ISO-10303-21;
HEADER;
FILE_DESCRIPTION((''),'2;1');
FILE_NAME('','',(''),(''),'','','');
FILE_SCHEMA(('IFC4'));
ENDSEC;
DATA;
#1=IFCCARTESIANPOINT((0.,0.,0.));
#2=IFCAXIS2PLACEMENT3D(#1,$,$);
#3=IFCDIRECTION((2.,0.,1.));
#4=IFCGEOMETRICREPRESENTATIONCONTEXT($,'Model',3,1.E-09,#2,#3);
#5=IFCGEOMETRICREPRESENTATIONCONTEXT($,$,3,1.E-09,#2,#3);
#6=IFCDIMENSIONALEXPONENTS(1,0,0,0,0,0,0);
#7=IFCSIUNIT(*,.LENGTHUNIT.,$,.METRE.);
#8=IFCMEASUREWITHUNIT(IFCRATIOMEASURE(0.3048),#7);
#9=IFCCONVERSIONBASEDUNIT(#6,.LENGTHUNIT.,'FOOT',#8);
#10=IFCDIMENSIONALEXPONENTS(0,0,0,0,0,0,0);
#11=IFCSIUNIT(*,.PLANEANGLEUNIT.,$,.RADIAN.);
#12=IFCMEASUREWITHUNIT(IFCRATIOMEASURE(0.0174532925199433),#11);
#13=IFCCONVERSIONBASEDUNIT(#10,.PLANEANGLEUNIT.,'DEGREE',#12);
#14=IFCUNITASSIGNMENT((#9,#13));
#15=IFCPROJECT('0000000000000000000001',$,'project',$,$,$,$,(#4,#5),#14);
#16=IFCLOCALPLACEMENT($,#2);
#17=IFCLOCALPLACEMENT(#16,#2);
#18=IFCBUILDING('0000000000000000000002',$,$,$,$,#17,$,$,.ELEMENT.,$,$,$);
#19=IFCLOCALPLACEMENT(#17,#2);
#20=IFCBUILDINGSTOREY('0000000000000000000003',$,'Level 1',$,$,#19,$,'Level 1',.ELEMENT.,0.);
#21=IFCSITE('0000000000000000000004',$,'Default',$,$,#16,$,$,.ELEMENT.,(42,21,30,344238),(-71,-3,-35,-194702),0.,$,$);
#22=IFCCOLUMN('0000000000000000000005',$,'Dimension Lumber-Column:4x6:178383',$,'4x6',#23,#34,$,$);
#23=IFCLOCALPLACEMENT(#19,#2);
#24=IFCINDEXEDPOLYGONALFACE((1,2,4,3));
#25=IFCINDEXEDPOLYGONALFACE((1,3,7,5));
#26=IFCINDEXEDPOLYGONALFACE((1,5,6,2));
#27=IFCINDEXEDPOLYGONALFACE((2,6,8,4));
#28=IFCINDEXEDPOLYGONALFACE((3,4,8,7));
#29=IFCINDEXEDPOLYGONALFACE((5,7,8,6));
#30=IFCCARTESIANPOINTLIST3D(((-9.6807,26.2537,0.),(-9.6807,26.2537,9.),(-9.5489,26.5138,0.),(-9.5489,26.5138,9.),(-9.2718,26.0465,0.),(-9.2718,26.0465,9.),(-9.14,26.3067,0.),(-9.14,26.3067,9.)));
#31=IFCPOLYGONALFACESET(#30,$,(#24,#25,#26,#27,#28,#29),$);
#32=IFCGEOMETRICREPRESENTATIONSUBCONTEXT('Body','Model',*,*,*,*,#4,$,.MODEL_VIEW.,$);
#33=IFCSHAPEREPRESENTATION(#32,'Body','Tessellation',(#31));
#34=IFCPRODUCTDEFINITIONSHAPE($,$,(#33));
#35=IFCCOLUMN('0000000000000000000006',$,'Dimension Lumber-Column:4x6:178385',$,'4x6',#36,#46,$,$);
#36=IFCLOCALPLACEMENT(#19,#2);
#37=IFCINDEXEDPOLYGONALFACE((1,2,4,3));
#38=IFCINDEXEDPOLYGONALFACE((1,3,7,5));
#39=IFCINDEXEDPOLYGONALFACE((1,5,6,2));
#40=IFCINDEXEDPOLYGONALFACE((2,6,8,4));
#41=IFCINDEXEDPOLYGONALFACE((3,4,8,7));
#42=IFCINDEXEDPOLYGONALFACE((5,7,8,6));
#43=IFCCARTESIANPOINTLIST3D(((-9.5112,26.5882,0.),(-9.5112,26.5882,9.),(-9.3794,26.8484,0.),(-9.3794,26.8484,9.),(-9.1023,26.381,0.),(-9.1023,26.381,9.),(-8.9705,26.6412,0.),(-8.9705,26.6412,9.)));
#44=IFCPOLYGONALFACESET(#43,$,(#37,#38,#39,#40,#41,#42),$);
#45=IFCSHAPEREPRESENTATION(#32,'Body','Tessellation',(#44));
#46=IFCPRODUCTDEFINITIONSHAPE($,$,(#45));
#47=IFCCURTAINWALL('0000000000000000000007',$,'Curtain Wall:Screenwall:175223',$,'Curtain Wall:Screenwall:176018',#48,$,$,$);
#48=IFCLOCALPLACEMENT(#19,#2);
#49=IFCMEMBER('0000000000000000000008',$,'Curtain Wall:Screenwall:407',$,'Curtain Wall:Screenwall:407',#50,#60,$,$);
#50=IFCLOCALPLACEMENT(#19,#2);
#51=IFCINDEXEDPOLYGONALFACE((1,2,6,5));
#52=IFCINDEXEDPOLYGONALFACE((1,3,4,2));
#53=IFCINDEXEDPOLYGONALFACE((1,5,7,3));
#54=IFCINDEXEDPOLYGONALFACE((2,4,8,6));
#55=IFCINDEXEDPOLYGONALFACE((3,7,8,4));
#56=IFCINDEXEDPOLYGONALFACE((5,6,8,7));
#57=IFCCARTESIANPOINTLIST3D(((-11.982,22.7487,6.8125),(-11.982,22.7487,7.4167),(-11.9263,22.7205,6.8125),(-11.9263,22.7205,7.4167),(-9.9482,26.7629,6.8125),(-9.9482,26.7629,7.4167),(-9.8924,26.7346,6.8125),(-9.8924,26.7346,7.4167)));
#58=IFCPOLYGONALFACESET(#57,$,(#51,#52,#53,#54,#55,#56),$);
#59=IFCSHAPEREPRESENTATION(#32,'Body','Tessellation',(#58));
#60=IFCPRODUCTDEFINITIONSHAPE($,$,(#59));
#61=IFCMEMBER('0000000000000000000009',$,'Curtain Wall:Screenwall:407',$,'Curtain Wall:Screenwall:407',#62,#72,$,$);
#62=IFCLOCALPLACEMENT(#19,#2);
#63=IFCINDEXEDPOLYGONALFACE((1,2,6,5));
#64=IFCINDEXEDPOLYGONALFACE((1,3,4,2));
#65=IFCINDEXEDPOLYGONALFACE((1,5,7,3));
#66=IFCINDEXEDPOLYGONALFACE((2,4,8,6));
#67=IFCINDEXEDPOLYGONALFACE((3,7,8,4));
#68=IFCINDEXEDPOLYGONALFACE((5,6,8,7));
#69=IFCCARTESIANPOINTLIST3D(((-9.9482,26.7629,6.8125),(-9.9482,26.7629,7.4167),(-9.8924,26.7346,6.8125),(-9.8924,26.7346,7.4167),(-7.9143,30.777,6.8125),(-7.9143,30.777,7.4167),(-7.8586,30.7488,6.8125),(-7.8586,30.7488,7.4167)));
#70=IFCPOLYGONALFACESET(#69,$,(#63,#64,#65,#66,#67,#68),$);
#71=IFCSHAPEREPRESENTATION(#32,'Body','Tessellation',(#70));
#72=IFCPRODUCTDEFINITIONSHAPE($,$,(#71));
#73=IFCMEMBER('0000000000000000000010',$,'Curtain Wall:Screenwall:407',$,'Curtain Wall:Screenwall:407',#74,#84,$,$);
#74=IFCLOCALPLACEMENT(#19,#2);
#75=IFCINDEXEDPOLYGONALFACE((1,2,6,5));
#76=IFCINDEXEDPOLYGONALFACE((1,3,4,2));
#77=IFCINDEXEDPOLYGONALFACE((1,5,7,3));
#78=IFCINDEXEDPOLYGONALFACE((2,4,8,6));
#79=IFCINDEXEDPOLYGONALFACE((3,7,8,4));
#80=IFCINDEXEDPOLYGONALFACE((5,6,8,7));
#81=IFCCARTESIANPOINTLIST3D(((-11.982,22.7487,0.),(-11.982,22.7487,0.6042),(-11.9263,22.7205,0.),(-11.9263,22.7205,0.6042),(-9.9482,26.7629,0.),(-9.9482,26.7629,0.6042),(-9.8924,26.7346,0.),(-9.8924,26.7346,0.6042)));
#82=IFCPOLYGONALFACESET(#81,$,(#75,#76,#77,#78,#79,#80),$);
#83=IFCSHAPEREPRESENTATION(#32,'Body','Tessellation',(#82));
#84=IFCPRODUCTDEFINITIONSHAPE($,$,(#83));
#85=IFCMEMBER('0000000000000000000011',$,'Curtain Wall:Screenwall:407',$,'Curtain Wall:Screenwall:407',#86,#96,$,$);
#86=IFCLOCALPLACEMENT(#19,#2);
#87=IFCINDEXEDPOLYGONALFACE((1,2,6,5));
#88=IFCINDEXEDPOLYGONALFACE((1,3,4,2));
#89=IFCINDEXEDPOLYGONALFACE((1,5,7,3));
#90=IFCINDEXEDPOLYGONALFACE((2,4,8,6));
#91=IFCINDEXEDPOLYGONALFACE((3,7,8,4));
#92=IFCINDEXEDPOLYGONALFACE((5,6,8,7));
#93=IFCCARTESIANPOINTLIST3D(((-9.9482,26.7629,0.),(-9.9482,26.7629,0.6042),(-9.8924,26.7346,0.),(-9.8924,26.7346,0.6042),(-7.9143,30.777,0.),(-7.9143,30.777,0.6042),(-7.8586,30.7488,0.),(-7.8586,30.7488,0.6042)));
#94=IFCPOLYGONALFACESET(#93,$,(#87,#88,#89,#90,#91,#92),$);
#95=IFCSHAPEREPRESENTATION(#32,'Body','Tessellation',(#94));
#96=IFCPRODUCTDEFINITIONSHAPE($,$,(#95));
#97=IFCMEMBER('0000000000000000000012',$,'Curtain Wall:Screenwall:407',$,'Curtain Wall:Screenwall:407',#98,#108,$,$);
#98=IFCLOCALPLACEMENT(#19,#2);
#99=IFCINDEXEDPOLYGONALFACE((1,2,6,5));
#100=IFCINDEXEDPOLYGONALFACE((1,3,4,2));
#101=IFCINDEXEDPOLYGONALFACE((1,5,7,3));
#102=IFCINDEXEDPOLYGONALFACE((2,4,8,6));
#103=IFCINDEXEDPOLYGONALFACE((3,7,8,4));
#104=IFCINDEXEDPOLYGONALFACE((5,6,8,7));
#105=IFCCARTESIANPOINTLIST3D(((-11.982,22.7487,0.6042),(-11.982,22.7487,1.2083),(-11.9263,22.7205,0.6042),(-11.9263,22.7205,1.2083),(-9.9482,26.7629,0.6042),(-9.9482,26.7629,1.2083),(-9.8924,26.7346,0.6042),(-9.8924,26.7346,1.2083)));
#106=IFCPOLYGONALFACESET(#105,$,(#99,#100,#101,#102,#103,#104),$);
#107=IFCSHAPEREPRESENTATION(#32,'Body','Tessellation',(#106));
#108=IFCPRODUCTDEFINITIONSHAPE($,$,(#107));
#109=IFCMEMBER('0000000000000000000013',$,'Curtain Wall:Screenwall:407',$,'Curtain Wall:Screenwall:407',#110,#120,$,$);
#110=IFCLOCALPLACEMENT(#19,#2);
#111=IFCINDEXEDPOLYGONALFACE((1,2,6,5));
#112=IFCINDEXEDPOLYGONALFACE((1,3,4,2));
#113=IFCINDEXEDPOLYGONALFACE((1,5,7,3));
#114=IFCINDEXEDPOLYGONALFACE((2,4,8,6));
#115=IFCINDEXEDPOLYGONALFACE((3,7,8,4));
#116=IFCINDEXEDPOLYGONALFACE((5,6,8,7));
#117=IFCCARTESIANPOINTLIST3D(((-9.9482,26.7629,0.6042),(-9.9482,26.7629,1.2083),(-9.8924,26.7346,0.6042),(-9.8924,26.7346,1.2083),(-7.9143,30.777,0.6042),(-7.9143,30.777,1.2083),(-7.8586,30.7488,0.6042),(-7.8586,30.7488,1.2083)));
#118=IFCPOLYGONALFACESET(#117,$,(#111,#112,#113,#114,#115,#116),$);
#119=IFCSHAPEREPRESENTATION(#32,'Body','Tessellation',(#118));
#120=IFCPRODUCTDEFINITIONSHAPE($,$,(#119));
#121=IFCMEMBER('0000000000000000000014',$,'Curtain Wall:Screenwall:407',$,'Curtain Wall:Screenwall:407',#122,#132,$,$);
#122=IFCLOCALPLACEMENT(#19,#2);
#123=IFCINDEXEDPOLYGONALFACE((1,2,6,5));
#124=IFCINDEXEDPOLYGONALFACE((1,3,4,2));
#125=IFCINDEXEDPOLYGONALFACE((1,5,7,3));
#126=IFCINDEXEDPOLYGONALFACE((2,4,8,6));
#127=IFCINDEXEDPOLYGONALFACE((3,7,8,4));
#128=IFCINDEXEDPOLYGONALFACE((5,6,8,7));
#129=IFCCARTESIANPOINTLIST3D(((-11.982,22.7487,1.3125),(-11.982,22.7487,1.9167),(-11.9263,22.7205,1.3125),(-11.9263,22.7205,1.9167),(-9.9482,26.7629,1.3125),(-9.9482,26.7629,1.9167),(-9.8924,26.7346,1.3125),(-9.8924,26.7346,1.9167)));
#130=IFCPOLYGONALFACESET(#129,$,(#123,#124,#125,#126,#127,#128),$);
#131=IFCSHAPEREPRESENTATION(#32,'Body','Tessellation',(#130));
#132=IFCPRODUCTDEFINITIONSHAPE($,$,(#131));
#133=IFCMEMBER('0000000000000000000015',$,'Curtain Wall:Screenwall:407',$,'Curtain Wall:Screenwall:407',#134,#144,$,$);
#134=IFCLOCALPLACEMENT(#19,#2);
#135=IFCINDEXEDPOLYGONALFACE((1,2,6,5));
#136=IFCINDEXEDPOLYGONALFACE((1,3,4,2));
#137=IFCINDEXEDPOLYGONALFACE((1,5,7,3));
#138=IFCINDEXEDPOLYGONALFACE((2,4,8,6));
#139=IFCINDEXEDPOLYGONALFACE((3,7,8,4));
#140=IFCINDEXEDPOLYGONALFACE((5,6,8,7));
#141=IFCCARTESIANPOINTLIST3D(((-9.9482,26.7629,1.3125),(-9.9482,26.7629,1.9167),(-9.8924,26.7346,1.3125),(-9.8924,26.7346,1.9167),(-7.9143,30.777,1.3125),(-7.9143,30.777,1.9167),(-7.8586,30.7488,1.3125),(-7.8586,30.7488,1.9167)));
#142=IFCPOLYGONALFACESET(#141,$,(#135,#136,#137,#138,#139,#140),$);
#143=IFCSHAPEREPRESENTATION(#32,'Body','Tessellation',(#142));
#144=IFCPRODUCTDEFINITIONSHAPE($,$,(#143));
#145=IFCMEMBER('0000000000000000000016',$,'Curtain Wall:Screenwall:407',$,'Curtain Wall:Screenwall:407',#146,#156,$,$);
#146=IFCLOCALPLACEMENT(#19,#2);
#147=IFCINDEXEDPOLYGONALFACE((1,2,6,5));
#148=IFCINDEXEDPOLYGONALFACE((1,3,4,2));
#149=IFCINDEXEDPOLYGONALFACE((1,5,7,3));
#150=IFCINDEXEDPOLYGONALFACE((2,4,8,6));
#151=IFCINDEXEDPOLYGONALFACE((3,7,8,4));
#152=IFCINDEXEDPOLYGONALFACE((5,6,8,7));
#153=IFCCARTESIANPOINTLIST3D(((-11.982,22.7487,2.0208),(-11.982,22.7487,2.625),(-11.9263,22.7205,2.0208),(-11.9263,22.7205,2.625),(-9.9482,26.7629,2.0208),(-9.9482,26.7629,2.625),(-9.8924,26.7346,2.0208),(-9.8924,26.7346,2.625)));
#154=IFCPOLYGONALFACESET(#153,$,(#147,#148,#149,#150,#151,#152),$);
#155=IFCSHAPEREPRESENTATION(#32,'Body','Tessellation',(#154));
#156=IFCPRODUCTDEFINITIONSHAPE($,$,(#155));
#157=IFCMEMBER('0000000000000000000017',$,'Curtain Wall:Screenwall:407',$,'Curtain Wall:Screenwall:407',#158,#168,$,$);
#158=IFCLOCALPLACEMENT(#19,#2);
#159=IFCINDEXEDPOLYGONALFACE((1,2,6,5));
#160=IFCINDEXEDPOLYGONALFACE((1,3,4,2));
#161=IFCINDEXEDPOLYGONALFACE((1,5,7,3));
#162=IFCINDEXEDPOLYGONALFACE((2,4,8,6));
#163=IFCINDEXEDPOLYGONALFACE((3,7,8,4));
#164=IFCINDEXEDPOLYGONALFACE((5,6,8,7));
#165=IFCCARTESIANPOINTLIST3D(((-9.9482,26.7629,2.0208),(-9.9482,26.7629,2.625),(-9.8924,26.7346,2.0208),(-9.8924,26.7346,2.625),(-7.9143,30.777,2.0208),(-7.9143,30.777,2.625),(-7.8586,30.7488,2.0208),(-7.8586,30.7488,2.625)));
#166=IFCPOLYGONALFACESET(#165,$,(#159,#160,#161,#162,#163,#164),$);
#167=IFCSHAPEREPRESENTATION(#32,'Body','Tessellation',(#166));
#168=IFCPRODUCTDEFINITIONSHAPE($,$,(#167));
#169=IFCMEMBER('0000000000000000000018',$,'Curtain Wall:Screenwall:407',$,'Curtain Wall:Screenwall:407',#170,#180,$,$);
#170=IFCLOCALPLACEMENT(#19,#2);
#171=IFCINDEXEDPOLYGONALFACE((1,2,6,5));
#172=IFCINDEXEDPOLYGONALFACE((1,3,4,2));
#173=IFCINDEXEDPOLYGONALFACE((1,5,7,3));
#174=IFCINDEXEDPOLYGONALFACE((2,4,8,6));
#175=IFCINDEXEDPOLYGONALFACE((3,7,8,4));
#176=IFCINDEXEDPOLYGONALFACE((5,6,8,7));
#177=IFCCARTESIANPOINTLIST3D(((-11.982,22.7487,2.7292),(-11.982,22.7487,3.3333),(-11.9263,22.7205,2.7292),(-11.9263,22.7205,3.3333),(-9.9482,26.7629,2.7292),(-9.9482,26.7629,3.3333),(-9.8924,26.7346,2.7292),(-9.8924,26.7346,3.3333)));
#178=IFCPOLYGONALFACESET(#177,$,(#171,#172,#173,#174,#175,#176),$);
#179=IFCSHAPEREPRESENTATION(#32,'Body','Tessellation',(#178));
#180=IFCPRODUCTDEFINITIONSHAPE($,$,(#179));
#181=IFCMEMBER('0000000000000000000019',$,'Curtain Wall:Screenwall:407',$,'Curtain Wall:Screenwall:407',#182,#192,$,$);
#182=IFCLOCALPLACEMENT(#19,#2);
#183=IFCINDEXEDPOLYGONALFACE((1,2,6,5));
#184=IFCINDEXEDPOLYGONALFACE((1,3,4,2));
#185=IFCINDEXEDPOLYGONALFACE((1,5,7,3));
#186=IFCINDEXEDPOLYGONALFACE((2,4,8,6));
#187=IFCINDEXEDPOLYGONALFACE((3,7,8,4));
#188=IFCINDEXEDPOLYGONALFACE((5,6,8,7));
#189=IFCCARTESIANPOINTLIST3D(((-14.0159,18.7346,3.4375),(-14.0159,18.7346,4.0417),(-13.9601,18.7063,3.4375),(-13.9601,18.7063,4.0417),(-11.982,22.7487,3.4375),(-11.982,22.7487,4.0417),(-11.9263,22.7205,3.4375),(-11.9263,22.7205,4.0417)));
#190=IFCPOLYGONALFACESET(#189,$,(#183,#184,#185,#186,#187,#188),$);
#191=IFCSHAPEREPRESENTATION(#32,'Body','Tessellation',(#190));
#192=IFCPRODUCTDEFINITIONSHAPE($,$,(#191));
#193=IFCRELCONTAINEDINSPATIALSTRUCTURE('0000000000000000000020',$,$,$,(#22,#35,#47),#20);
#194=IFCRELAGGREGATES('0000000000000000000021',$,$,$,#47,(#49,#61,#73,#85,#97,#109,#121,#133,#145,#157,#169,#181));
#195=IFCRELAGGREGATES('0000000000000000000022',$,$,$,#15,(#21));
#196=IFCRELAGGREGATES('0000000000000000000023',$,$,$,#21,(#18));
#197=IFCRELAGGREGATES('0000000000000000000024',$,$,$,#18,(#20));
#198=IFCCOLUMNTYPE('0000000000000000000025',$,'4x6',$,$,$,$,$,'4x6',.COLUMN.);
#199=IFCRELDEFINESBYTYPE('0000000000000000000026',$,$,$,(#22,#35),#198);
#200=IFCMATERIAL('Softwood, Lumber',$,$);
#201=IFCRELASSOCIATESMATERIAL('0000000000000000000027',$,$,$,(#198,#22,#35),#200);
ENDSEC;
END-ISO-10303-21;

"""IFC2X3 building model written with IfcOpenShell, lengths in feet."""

from ifc_helpers import new_model, entity, si_unit, converted_unit, direction, frame, frame_2d, origin, origin_2d_with_axis, place, context, subcontext, project, spatial, rectangle, extrude, source, transform, mapped, material, type_object, type_shapes, element, aggregate, save


model = new_model("IFC2X3")

# Units and contexts
model_context = context("Model", 3, precision=1e-09, world=origin(), true_north=direction((2.0, 0.0, 1.0)))
context_of_model = context(None, 3, precision=1e-09, world=origin(), true_north=direction((2.0, 0.0, 1.0)))
body_context = subcontext(model_context, "Body", "Model", "MODEL_VIEW")
ifc_project = project(units=[converted_unit("LENGTHUNIT", "FOOT", entity("IfcRatioMeasure", 0.3048), si_unit("LENGTHUNIT", "METRE"), dimensions=[1, 0, 0, 0, 0, 0, 0]), converted_unit("PLANEANGLEUNIT", "DEGREE", entity("IfcRatioMeasure", 0.0174532925199433), si_unit("PLANEANGLEUNIT", "RADIAN"), dimensions=[0, 0, 0, 0, 0, 0, 0])], contexts=[model_context, context_of_model])

# Site, building, storey
site_placement = place(None, origin())
site = spatial("IfcSite", under=ifc_project, at=site_placement, Name="Default", CompositionType="ELEMENT", RefLatitude=(42, 21, 30, 344238), RefLongitude=(-71, -3, -35, -194702), RefElevation=0.0)
building_placement = place(site_placement, origin())
building = spatial("IfcBuilding", under=site, at=building_placement, CompositionType="ELEMENT")
storey_placement = place(building_placement, origin())
storey = spatial("IfcBuildingStorey", under=building, at=storey_placement, Name="Level 1", LongName="Level 1", CompositionType="ELEMENT", Elevation=0.0)

# Columns
ifc_material_1 = material(Name="Softwood, Lumber")
column_type = type_object("IfcColumnType", Name="4x6", ElementType="4x6", PredefinedType="COLUMN", material=ifc_material_1)
shared_shape_1 = source(origin(), body_context, "Body", "SweptSolid", [
    extrude(rectangle(XDim=0.2917, YDim=0.4583, at=origin_2d_with_axis()), frame((0.0, 0.0, 0.0), z_axis=(0.0, 0.0, 1.0), x_axis=(-1.0, 0.0, 0.0)), (0.0, 0.0, 1.0), 9.0),
])
type_shapes(column_type, [shared_shape_1])
for number, where, z_axis, x_axis, name in (
    (1, (-9.4103, 26.2802, 0.0), (0.0, 0.0, 1.0), (0.451968, 0.892034, 0.0), "Dimension Lumber-Column:4x6:178383"),
    (2, (-9.2409, 26.6147, 0.0), (0.0, 0.0, 1.0), (0.451968, 0.892034, 0.0), "Dimension Lumber-Column:4x6:178385"),
):
    element("IfcColumn", number, at=place(storey_placement, frame(where, z_axis=z_axis, x_axis=x_axis)), inside=storey, type_object=column_type, material=ifc_material_1, Name=name, ObjectType="4x6", context=body_context, shape_type="MappedRepresentation", body=[
        mapped(shared_shape_1, transform((0.0, 0.0, 0.0), scale=1.0)),
    ])

# Curtain wall, members
curtain_wall_placement = place(storey_placement, origin())
curtain_wall = element("IfcCurtainWall", 3, at=curtain_wall_placement, inside=storey, Name="Curtain Wall:Screenwall:175223", ObjectType="Curtain Wall:Screenwall:176018")
member_1_placement = place(curtain_wall_placement, frame((-11.982, 22.7205, 6.8125)))
member_1 = element("IfcMember", 4, at=member_1_placement, Name="Curtain Wall:Screenwall:407", ObjectType="Curtain Wall:Screenwall:407", context=body_context, shape_type="SweptSolid", body=[
    extrude(rectangle(XDim=4.5, YDim=0.0625, at=frame_2d((0.0, 0.0), x_axis=(1.0, 0.0))), frame((1.0448, 2.0212, 0.0), z_axis=(0.0, 0.0, 1.0), x_axis=(-0.451968, -0.892034, 0.0)), (0.0, 0.0, 1.0), 0.6042),
])
member_2_placement = place(curtain_wall_placement, frame((-9.9482, 26.7346, 6.8125)))
member_2 = element("IfcMember", 5, at=member_2_placement, Name="Curtain Wall:Screenwall:407", ObjectType="Curtain Wall:Screenwall:407", context=body_context, shape_type="SweptSolid", body=[
    extrude(rectangle(XDim=4.5, YDim=0.0625, at=frame_2d((0.0, 0.0), x_axis=(1.0, 0.0))), frame((1.0448, 2.0212, 0.0), z_axis=(0.0, 0.0, 1.0), x_axis=(-0.451968, -0.892034, 0.0)), (0.0, 0.0, 1.0), 0.6042),
])
member_3_placement = place(curtain_wall_placement, frame((-11.982, 22.7205, 0.0)))
member_3 = element("IfcMember", 6, at=member_3_placement, Name="Curtain Wall:Screenwall:407", ObjectType="Curtain Wall:Screenwall:407", context=body_context, shape_type="SweptSolid", body=[
    extrude(rectangle(XDim=4.5, YDim=0.0625, at=frame_2d((0.0, 0.0), x_axis=(1.0, 0.0))), frame((1.0448, 2.0212, 0.0), z_axis=(0.0, 0.0, 1.0), x_axis=(0.451968, 0.892034, 0.0)), (0.0, 0.0, 1.0), 0.6042),
])
member_4_placement = place(curtain_wall_placement, frame((-9.9482, 26.7346, 0.0)))
member_4 = element("IfcMember", 7, at=member_4_placement, Name="Curtain Wall:Screenwall:407", ObjectType="Curtain Wall:Screenwall:407", context=body_context, shape_type="SweptSolid", body=[
    extrude(rectangle(XDim=4.5, YDim=0.0625, at=frame_2d((0.0, 0.0), x_axis=(1.0, 0.0))), frame((1.0448, 2.0212, 0.0), z_axis=(0.0, 0.0, 1.0), x_axis=(0.451968, 0.892034, 0.0)), (0.0, 0.0, 1.0), 0.6042),
])
member_5_placement = place(curtain_wall_placement, frame((-11.982, 22.7205, 0.6042)))
member_5 = element("IfcMember", 8, at=member_5_placement, Name="Curtain Wall:Screenwall:407", ObjectType="Curtain Wall:Screenwall:407", context=body_context, shape_type="SweptSolid", body=[
    extrude(rectangle(XDim=4.5, YDim=0.0625, at=frame_2d((0.0, 0.0), x_axis=(1.0, 0.0))), frame((1.0448, 2.0212, 0.0), z_axis=(0.0, 0.0, 1.0), x_axis=(-0.451968, -0.892034, 0.0)), (0.0, 0.0, 1.0), 0.6042),
])
member_6_placement = place(curtain_wall_placement, frame((-9.9482, 26.7346, 0.6042)))
member_6 = element("IfcMember", 9, at=member_6_placement, Name="Curtain Wall:Screenwall:407", ObjectType="Curtain Wall:Screenwall:407", context=body_context, shape_type="SweptSolid", body=[
    extrude(rectangle(XDim=4.5, YDim=0.0625, at=origin_2d_with_axis()), frame((1.0448, 2.0212, 0.0), z_axis=(0.0, 0.0, 1.0), x_axis=(-0.451968, -0.892034, 0.0)), (0.0, 0.0, 1.0), 0.6042),
])
member_7_placement = place(curtain_wall_placement, frame((-11.982, 22.7205, 1.3125)))
member_7 = element("IfcMember", 10, at=member_7_placement, Name="Curtain Wall:Screenwall:407", ObjectType="Curtain Wall:Screenwall:407", context=body_context, shape_type="SweptSolid", body=[
    extrude(rectangle(XDim=4.5, YDim=0.0625, at=frame_2d((0.0, 0.0), x_axis=(1.0, 0.0))), frame((1.0448, 2.0212, 0.0), z_axis=(0.0, 0.0, 1.0), x_axis=(-0.451968, -0.892034, 0.0)), (0.0, 0.0, 1.0), 0.6042),
])
member_8_placement = place(curtain_wall_placement, frame((-9.9482, 26.7346, 1.3125)))
member_8 = element("IfcMember", 11, at=member_8_placement, Name="Curtain Wall:Screenwall:407", ObjectType="Curtain Wall:Screenwall:407", context=body_context, shape_type="SweptSolid", body=[
    extrude(rectangle(XDim=4.5, YDim=0.0625, at=origin_2d_with_axis()), frame((1.0448, 2.0212, 0.0), z_axis=(0.0, 0.0, 1.0), x_axis=(-0.451968, -0.892034, 0.0)), (0.0, 0.0, 1.0), 0.6042),
])
member_9_placement = place(curtain_wall_placement, frame((-11.982, 22.7205, 2.0208)))
member_9 = element("IfcMember", 12, at=member_9_placement, Name="Curtain Wall:Screenwall:407", ObjectType="Curtain Wall:Screenwall:407", context=body_context, shape_type="SweptSolid", body=[
    extrude(rectangle(XDim=4.5, YDim=0.0625, at=frame_2d((0.0, 0.0), x_axis=(1.0, 0.0))), frame((1.0448, 2.0212, 0.0), z_axis=(0.0, 0.0, 1.0), x_axis=(-0.451968, -0.892034, 0.0)), (0.0, 0.0, 1.0), 0.6042),
])
member_10_placement = place(curtain_wall_placement, frame((-9.9482, 26.7346, 2.0208)))
member_10 = element("IfcMember", 13, at=member_10_placement, Name="Curtain Wall:Screenwall:407", ObjectType="Curtain Wall:Screenwall:407", context=body_context, shape_type="SweptSolid", body=[
    extrude(rectangle(XDim=4.5, YDim=0.0625, at=origin_2d_with_axis()), frame((1.0448, 2.0212, 0.0), z_axis=(0.0, 0.0, 1.0), x_axis=(-0.451968, -0.892034, 0.0)), (0.0, 0.0, 1.0), 0.6042),
])
member_11_placement = place(curtain_wall_placement, frame((-11.982, 22.7205, 2.7292)))
member_11 = element("IfcMember", 14, at=member_11_placement, Name="Curtain Wall:Screenwall:407", ObjectType="Curtain Wall:Screenwall:407", context=body_context, shape_type="SweptSolid", body=[
    extrude(rectangle(XDim=4.5, YDim=0.0625, at=frame_2d((0.0, 0.0), x_axis=(1.0, 0.0))), frame((1.0448, 2.0212, 0.0), z_axis=(0.0, 0.0, 1.0), x_axis=(-0.451968, -0.892034, 0.0)), (0.0, 0.0, 1.0), 0.6042),
])
member_12_placement = place(curtain_wall_placement, frame((-14.0159, 18.7063, 3.4375)))
member_12 = element("IfcMember", 15, at=member_12_placement, Name="Curtain Wall:Screenwall:407", ObjectType="Curtain Wall:Screenwall:407", context=body_context, shape_type="SweptSolid", body=[
    extrude(rectangle(XDim=4.5, YDim=0.0625, at=frame_2d((0.0, 0.0), x_axis=(1.0, 0.0))), frame((1.0448, 2.0212, 0.0), z_axis=(0.0, 0.0, 1.0), x_axis=(-0.451968, -0.892034, 0.0)), (0.0, 0.0, 1.0), 0.6042),
])
aggregate(curtain_wall, [member_1, member_2, member_3, member_4, member_5, member_6, member_7, member_8, member_9, member_10, member_11, member_12])

save(model, "model.ifc")
